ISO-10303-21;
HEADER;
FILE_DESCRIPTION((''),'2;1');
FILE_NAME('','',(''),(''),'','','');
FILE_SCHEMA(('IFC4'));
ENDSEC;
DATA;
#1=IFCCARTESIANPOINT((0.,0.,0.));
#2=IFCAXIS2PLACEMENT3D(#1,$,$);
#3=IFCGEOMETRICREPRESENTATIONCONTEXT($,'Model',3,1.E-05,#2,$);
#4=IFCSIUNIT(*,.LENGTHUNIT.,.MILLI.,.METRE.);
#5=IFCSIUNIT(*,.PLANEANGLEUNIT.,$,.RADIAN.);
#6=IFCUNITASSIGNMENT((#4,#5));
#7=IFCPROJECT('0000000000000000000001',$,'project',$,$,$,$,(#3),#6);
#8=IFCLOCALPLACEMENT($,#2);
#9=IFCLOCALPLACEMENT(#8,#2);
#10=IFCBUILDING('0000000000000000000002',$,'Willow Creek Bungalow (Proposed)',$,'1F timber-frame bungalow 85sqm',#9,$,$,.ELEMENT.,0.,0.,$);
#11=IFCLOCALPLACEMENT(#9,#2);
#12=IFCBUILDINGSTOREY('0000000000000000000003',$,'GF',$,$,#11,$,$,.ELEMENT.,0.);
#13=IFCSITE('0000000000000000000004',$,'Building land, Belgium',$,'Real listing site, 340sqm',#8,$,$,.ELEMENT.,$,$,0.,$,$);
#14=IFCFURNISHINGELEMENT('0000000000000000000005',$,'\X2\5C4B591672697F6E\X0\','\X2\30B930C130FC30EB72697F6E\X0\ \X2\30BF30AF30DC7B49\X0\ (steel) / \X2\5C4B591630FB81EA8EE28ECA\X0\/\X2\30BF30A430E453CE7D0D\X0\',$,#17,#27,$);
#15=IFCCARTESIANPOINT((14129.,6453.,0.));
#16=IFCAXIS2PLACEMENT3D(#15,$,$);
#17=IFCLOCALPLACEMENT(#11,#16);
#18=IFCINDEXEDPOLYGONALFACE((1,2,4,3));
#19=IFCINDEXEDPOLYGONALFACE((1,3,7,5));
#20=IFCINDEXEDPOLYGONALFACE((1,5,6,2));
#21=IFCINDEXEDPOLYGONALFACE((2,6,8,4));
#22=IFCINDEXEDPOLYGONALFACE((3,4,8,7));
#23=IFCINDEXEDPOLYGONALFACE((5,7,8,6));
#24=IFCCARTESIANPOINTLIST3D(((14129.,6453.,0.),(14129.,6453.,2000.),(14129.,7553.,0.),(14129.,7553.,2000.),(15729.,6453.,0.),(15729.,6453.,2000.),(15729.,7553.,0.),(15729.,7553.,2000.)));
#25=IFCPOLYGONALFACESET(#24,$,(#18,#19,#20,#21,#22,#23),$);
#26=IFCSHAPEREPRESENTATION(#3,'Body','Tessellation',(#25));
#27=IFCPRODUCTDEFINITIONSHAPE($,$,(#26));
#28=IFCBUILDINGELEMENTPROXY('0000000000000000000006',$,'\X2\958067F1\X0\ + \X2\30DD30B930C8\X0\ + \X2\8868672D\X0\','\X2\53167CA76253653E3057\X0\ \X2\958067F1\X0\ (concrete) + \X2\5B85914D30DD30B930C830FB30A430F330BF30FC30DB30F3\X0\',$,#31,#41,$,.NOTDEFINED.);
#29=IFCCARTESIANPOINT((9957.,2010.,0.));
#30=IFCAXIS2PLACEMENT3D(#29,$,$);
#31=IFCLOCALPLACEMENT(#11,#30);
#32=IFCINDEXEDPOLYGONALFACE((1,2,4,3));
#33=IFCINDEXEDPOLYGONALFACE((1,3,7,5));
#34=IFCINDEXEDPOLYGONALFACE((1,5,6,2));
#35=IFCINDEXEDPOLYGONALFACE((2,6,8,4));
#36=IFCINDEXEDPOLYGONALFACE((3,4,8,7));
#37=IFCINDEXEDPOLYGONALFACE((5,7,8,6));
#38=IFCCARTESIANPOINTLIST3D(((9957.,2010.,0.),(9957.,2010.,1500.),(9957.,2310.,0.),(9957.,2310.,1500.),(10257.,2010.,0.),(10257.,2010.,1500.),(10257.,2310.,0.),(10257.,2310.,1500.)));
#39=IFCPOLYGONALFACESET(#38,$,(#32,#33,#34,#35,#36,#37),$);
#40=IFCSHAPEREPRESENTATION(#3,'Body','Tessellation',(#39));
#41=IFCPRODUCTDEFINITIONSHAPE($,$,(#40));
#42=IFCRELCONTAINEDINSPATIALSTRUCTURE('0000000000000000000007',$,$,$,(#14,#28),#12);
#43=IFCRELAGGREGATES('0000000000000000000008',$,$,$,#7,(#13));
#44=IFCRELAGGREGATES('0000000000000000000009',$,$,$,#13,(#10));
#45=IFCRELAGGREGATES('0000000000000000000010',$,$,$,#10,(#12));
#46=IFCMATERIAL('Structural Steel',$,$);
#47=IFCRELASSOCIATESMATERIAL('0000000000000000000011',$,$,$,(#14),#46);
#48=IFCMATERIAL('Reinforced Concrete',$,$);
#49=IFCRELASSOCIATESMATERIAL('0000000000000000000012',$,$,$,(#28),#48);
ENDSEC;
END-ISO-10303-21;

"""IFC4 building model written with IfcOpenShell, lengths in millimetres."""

from ifc_helpers import new_model, si_unit, frame, frame_2d, origin, place, context, project, spatial, rectangle, extrude, material, element, save


model = new_model("IFC4")

# Units and contexts
model_context = context("Model", 3, precision=1e-05, world=origin())
ifc_project = project(units=[si_unit("LENGTHUNIT", "METRE", prefix="MILLI"), si_unit("PLANEANGLEUNIT", "RADIAN")], contexts=[model_context])

# Site, building, storey
site_placement = place(None, origin())
site = spatial("IfcSite", under=ifc_project, at=site_placement, Name="Building land, Belgium", ObjectType="Real listing site, 340sqm", CompositionType="ELEMENT", RefElevation=0.0)
building_placement = place(site_placement, origin())
building = spatial("IfcBuilding", under=site, at=building_placement, Name="Willow Creek Bungalow (Proposed)", ObjectType="1F timber-frame bungalow 85sqm", CompositionType="ELEMENT", ElevationOfRefHeight=0.0, ElevationOfTerrain=0.0)
storey_placement = place(building_placement, origin())
storey = spatial("IfcBuildingStorey", under=building, at=storey_placement, Name="GF", CompositionType="ELEMENT", Elevation=0.0)

# Shared definitions
ifc_material_1 = material(Name="Reinforced Concrete")

# Shared definitions
ifc_material_2 = material(Name="Structural Steel")

# Furnishing element
furnishing_1_placement = place(storey_placement, frame((14129.0, 6453.0, 0.0)))
element("IfcFurnishingElement", 1, at=furnishing_1_placement, inside=storey, material=ifc_material_2, Name="屋外物置", Description="スチール物置 タクボ等 (steel) / 屋外・自転車/タイヤ収納", context=model_context, shape_type="SweptSolid", body=[
    extrude(rectangle(XDim=1600.0, YDim=1100.0, at=frame_2d((800.0, 550.0))), frame((14129.0, 6453.0, 0.0)), (0.0, 0.0, 1.0), 2000.0),
])

# Building element proxy
proxy_placement = place(storey_placement, frame((9957.0, 2010.0, 0.0)))
element("IfcBuildingElementProxy", 2, at=proxy_placement, inside=storey, material=ifc_material_1, Name="門柱 + ポスト + 表札", Description="化粧打放し 門柱 (concrete) + 宅配ポスト・インターホン", PredefinedType="NOTDEFINED", context=model_context, shape_type="SweptSolid", body=[
    extrude(rectangle(XDim=300.0, YDim=300.0, at=frame_2d((150.0, 150.0))), frame((9957.0, 2010.0, 0.0)), (0.0, 0.0, 1.0), 1500.0),
])

save(model, "model.ifc")
